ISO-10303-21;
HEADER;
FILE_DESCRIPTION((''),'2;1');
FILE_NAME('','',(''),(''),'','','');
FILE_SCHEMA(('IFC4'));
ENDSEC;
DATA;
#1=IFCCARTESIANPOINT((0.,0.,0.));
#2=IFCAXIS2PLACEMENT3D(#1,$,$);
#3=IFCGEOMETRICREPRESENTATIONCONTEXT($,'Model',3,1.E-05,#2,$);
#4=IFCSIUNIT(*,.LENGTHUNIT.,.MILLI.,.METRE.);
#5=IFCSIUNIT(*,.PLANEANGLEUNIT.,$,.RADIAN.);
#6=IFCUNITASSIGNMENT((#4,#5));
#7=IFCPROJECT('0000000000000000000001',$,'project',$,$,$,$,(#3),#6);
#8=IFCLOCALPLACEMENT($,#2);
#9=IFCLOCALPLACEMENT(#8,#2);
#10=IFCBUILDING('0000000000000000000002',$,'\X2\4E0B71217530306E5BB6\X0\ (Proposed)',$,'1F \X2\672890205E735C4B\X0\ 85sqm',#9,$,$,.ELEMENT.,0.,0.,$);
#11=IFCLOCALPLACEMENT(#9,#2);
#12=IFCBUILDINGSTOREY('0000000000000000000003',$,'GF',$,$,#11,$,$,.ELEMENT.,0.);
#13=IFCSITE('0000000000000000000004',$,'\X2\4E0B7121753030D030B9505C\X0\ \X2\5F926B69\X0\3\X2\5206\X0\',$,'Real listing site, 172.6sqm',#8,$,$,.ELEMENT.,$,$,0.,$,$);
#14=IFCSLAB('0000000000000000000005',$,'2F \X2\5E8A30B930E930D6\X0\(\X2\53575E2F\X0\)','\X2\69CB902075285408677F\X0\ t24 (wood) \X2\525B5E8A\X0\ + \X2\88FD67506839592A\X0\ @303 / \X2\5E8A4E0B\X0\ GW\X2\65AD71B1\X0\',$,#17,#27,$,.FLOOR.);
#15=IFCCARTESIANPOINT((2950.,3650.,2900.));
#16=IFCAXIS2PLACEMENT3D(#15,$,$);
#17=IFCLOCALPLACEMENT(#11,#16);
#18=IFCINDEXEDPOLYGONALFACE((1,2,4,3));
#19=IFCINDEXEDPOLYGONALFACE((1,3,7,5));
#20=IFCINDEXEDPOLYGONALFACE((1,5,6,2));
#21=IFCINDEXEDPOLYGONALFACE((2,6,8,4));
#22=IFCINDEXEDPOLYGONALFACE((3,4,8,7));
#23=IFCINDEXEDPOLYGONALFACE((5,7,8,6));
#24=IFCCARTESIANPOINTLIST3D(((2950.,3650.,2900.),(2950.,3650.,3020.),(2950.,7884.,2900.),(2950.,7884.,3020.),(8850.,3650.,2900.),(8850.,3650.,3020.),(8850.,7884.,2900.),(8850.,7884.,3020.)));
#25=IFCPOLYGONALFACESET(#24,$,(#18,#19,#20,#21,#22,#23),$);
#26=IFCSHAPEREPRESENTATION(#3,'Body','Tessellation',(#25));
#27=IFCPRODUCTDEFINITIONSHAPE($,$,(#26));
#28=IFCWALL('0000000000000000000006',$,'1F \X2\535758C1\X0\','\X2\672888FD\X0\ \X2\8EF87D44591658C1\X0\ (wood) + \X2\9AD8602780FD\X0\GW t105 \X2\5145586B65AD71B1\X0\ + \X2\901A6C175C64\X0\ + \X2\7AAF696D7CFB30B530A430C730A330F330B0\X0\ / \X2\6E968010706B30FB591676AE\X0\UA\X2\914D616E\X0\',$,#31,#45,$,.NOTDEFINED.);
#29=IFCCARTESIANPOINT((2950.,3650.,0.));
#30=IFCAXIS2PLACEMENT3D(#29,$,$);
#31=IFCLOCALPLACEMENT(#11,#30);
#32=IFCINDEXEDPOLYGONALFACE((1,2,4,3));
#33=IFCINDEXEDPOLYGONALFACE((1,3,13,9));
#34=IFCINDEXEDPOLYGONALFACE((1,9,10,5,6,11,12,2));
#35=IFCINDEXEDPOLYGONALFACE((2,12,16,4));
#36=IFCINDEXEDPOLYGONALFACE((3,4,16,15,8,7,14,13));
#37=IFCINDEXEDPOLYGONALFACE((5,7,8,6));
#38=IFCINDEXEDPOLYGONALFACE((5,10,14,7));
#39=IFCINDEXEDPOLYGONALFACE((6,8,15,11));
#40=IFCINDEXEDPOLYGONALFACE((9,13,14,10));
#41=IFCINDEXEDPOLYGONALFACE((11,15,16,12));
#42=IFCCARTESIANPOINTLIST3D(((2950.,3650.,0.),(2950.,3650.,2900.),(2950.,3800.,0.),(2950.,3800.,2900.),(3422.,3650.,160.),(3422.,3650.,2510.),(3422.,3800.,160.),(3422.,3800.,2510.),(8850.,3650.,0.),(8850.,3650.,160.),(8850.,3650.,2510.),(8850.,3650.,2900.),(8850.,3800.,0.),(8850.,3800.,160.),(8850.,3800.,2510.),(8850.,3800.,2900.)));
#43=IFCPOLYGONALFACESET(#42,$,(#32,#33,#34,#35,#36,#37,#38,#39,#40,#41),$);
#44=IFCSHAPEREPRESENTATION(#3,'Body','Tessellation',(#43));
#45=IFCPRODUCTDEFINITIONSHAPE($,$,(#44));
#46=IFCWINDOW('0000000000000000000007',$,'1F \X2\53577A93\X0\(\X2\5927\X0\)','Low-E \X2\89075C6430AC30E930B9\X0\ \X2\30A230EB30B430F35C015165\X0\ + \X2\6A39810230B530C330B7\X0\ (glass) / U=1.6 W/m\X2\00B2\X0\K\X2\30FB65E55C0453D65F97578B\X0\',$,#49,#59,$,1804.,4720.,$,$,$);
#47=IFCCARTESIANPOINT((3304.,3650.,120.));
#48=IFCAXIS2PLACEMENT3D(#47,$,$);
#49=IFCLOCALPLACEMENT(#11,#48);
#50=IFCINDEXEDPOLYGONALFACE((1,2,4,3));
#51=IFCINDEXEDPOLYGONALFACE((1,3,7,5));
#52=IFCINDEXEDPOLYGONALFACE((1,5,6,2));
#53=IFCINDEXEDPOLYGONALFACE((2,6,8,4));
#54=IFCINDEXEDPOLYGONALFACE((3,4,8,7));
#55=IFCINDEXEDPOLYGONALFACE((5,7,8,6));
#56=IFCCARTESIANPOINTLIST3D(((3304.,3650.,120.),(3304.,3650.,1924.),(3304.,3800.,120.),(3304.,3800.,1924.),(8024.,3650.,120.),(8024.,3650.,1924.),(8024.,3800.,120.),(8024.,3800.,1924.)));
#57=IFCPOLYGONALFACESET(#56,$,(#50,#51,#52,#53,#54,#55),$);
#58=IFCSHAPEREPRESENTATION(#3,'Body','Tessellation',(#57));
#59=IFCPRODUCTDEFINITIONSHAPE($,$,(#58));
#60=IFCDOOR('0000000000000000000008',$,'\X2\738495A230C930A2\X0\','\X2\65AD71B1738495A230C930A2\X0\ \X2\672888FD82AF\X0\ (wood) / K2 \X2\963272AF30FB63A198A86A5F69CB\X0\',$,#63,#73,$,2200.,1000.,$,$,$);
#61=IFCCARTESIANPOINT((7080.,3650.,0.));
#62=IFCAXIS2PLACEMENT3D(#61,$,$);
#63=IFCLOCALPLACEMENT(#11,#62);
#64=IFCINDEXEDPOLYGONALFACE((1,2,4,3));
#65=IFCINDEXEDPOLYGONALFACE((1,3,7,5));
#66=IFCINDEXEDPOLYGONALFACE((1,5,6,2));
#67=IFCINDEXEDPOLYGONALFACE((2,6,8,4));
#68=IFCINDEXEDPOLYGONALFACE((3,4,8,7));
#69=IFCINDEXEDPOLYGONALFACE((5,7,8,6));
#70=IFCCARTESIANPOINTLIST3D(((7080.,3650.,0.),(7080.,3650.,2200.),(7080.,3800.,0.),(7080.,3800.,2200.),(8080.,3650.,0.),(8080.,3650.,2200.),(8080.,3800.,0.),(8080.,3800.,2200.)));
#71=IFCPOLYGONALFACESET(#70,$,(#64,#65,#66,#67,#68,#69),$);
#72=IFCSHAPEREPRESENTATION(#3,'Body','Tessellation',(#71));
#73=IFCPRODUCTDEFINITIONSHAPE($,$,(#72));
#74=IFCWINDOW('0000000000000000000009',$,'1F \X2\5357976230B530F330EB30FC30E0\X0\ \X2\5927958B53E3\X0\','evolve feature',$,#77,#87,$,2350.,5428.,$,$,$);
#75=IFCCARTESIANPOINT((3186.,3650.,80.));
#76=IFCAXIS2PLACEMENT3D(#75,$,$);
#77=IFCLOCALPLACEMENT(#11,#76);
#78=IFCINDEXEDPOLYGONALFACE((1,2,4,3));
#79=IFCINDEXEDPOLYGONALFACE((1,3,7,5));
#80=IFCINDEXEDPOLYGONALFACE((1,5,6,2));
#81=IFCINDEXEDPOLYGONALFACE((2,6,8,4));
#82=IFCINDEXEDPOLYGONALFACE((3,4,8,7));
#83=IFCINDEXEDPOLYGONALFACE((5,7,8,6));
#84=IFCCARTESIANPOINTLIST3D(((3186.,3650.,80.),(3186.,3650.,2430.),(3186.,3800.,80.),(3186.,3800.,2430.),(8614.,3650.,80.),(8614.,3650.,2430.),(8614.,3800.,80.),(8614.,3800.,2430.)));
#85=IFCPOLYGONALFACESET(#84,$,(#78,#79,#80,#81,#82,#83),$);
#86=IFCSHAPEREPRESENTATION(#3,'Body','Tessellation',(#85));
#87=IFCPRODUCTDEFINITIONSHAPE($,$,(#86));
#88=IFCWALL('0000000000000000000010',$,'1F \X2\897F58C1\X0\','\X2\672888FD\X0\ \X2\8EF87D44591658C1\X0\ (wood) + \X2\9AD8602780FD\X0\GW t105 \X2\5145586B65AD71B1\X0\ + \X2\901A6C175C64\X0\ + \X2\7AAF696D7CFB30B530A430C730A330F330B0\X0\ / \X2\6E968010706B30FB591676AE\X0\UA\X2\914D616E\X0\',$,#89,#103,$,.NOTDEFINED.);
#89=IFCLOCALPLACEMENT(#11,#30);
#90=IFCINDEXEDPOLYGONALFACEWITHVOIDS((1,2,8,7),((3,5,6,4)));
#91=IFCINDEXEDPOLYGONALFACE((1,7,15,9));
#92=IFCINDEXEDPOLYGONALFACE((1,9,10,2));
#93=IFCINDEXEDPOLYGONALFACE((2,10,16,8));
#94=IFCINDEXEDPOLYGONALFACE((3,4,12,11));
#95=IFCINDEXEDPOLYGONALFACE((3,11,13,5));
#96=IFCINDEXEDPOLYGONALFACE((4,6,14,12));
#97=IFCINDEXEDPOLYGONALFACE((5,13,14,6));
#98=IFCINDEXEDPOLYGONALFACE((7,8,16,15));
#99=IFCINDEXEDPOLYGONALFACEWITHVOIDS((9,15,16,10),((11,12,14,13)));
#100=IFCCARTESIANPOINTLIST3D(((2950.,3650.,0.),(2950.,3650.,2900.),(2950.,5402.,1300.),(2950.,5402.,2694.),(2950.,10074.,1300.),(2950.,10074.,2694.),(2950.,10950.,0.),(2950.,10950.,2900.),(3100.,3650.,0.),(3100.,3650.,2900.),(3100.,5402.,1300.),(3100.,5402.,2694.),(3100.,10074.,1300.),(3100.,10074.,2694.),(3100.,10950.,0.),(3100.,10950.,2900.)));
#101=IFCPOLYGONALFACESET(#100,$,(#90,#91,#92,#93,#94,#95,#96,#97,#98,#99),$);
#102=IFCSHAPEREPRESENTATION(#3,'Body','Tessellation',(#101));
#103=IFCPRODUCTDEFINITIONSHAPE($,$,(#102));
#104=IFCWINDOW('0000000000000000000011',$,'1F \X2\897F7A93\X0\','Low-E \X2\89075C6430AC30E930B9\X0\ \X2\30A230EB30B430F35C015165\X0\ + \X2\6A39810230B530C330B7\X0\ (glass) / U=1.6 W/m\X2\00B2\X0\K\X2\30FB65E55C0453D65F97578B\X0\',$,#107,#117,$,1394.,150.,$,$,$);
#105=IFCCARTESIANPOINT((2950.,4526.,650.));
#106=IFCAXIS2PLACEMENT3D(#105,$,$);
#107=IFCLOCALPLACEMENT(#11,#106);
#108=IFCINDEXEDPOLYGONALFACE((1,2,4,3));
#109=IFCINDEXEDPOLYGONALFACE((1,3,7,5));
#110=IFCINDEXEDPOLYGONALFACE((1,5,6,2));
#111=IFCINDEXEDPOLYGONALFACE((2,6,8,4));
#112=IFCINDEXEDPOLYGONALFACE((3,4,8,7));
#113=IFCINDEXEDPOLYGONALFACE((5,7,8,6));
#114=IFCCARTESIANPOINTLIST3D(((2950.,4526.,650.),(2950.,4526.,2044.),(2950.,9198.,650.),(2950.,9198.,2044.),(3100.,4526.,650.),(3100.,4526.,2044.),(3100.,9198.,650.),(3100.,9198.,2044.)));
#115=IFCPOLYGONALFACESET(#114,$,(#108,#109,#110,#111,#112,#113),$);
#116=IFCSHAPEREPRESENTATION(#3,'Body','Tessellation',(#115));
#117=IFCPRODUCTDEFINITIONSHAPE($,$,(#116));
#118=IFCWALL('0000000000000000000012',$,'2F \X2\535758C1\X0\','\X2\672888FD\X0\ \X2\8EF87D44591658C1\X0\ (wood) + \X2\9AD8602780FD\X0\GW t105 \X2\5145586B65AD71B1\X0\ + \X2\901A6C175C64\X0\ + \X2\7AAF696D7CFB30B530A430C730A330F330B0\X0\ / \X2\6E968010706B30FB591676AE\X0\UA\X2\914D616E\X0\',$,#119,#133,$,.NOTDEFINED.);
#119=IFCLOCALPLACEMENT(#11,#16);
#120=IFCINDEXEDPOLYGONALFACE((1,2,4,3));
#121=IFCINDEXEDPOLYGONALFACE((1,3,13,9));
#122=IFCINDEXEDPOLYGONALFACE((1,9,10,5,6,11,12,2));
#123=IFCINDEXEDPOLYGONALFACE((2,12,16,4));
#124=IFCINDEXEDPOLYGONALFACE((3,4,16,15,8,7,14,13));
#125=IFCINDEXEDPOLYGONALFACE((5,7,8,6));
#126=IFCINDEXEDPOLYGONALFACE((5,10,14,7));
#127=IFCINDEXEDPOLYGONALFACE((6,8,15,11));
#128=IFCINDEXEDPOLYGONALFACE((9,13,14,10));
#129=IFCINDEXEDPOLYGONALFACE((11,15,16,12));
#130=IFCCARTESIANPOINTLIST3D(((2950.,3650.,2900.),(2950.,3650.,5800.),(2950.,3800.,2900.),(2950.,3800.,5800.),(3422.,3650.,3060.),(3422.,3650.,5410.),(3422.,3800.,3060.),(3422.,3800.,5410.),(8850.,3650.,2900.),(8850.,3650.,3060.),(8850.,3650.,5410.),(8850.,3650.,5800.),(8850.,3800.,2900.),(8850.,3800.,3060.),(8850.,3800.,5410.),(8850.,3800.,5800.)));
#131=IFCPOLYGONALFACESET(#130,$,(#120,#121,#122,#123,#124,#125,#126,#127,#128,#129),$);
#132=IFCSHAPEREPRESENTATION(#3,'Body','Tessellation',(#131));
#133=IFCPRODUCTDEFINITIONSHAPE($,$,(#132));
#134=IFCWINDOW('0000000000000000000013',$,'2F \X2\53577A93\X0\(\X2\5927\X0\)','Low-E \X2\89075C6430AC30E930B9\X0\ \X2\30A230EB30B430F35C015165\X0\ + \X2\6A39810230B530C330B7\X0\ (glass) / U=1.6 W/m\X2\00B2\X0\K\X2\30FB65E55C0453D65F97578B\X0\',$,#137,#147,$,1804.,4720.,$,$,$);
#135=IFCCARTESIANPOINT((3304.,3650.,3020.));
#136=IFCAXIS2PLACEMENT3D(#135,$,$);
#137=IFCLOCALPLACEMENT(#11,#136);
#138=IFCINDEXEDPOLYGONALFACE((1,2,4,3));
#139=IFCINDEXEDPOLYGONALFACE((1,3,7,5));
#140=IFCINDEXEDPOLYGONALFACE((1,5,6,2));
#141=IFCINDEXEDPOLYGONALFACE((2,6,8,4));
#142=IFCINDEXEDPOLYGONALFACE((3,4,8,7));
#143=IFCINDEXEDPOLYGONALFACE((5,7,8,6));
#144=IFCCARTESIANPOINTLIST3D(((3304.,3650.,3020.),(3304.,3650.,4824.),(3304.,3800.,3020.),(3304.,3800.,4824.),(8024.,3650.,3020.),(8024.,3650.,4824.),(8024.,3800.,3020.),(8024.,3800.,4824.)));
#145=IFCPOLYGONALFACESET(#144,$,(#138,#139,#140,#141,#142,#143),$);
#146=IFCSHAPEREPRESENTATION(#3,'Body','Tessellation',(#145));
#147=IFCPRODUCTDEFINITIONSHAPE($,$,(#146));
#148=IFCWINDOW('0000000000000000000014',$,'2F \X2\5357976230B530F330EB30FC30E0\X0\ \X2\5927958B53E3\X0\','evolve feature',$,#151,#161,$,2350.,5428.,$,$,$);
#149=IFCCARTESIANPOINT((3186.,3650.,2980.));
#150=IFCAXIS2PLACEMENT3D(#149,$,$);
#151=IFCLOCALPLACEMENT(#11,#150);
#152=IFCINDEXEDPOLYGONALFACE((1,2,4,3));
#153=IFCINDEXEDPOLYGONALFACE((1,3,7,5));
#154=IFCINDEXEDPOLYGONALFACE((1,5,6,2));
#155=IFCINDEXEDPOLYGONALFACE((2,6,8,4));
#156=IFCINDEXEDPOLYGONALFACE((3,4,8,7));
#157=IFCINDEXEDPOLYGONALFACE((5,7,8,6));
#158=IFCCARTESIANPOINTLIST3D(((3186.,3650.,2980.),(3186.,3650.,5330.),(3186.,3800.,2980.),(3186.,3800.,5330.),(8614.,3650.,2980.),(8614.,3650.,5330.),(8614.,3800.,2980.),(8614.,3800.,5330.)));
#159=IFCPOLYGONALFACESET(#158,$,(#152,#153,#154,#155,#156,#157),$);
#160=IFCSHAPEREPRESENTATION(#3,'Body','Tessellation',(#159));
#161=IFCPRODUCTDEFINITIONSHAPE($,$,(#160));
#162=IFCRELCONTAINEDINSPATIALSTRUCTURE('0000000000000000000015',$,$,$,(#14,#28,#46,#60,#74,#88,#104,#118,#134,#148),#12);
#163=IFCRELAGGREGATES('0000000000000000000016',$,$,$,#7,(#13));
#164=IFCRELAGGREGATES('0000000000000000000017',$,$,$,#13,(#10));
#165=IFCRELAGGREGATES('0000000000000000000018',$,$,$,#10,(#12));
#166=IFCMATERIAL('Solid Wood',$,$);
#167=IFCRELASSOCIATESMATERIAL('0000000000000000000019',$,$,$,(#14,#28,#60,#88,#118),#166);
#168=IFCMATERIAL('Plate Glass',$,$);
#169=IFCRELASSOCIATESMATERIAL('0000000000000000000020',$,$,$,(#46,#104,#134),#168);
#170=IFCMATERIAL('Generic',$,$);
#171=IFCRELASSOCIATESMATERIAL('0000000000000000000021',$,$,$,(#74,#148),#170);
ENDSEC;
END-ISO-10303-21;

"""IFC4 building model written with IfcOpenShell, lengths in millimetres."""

from ifc_helpers import new_model, si_unit, frame, frame_2d, origin, place, context, project, spatial, rectangle, extrude, material, element, fill, save


model = new_model("IFC4")

# Units and contexts
model_context = context("Model", 3, precision=1e-05, world=origin())
ifc_project = project(units=[si_unit("LENGTHUNIT", "METRE", prefix="MILLI"), si_unit("PLANEANGLEUNIT", "RADIAN")], contexts=[model_context])

# Site, building, storey
site_placement = place(None, origin())
site = spatial("IfcSite", under=ifc_project, at=site_placement, Name="下無田バス停 徒歩3分", ObjectType="Real listing site, 172.6sqm", CompositionType="ELEMENT", RefElevation=0.0)
building_placement = place(site_placement, origin())
building = spatial("IfcBuilding", under=site, at=building_placement, Name="下無田の家 (Proposed)", ObjectType="1F 木造平屋 85sqm", CompositionType="ELEMENT", ElevationOfRefHeight=0.0, ElevationOfTerrain=0.0)
storey_placement = place(building_placement, origin())
storey = spatial("IfcBuildingStorey", under=building, at=storey_placement, Name="GF", CompositionType="ELEMENT", Elevation=0.0)

# Slab
ifc_material_1 = material(Name="Solid Wood")
slab_1_placement = place(storey_placement, frame((2950.0, 3650.0, 2900.0)))
element("IfcSlab", 1, at=slab_1_placement, inside=storey, material=ifc_material_1, Name="2F 床スラブ(南帯)", Description="構造用合板 t24 (wood) 剛床 + 製材根太 @303 / 床下 GW断熱", PredefinedType="FLOOR", context=model_context, shape_type="SweptSolid", body=[
    extrude(rectangle(XDim=5900.0, YDim=4234.0, at=frame_2d((2950.0, 2117.0))), frame((2950.0, 3650.0, 2900.0)), (0.0, 0.0, 1.0), 120.0),
])
ifc_material_2 = material(Name="Generic")

# Wall, openings, windows, door
wall_1_placement = place(storey_placement, frame((2950.0, 3650.0, 0.0)))
wall_1 = element("IfcWall", 2, at=wall_1_placement, inside=storey, material=ifc_material_1, Name="1F 南壁", Description="木製 軸組外壁 (wood) + 高性能GW t105 充填断熱 + 通気層 + 窯業系サイディング / 準耐火・外皮UA配慮", PredefinedType="NOTDEFINED", context=model_context, shape_type="SweptSolid", body=[
    extrude(rectangle(XDim=5900.0, YDim=150.0, at=frame_2d((2950.0, 75.0))), frame((2950.0, 3650.0, 0.0)), (0.0, 0.0, 1.0), 2900.0),
])
opening_1_placement = place(storey_placement, frame((3304.0, 3650.0, 120.0)))
opening_1 = element("IfcOpeningElement", 3, at=opening_1_placement, cuts=wall_1, PredefinedType="NOTDEFINED", context=model_context, shape_type="SweptSolid", body=[
    extrude(rectangle(XDim=4720.0, YDim=150.0, at=frame_2d((2360.0, 75.0))), frame((3304.0, 3650.0, 120.0)), (0.0, 0.0, 1.0), 1804.0),
])
opening_2_placement = place(storey_placement, frame((7080.0, 3650.0, 0.0)))
opening_2 = element("IfcOpeningElement", 4, at=opening_2_placement, cuts=wall_1, PredefinedType="NOTDEFINED", context=model_context, shape_type="SweptSolid", body=[
    extrude(rectangle(XDim=1000.0, YDim=150.0, at=frame_2d((500.0, 75.0))), frame((7080.0, 3650.0, 0.0)), (0.0, 0.0, 1.0), 2200.0),
])
opening_3_placement = place(storey_placement, frame((3186.0, 3650.0, 80.0)))
opening_3 = element("IfcOpeningElement", 5, at=opening_3_placement, cuts=wall_1, PredefinedType="NOTDEFINED", context=model_context, shape_type="SweptSolid", body=[
    extrude(rectangle(XDim=5428.0, YDim=150.0, at=frame_2d((2714.0, 75.0))), frame((3186.0, 3650.0, 80.0)), (0.0, 0.0, 1.0), 2350.0),
])
ifc_material_3 = material(Name="Plate Glass")
window_1_placement = place(storey_placement, frame((3304.0, 3650.0, 120.0)))
window_1 = element("IfcWindow", 6, at=window_1_placement, inside=storey, material=ifc_material_3, Name="1F 南窓(大)", Description="Low-E 複層ガラス アルゴン封入 + 樹脂サッシ (glass) / U=1.6 W/m²K・日射取得型", OverallHeight=1804.0, OverallWidth=4720.0, context=model_context, shape_type="SweptSolid", body=[
    extrude(rectangle(XDim=4720.0, YDim=150.0, at=frame_2d((2360.0, 75.0))), frame((3304.0, 3650.0, 120.0)), (0.0, 0.0, 1.0), 1804.0),
])
fill(opening_1, window_1)
door_placement = place(storey_placement, frame((7080.0, 3650.0, 0.0)))
door = element("IfcDoor", 7, at=door_placement, inside=storey, material=ifc_material_1, Name="玄関ドア", Description="断熱玄関ドア 木製芯 (wood) / K2 防犯・採風機構", OverallHeight=2200.0, OverallWidth=1000.0, context=model_context, shape_type="SweptSolid", body=[
    extrude(rectangle(XDim=1000.0, YDim=150.0, at=frame_2d((500.0, 75.0))), frame((7080.0, 3650.0, 0.0)), (0.0, 0.0, 1.0), 2200.0),
])
fill(opening_2, door)
window_2_placement = place(storey_placement, frame((3186.0, 3650.0, 80.0)))
window_2 = element("IfcWindow", 8, at=window_2_placement, inside=storey, material=ifc_material_2, Name="1F 南面サンルーム 大開口", Description="evolve feature", OverallHeight=2350.0, OverallWidth=5428.0, context=model_context, shape_type="SweptSolid", body=[
    extrude(rectangle(XDim=5428.0, YDim=150.0, at=frame_2d((2714.0, 75.0))), frame((3186.0, 3650.0, 80.0)), (0.0, 0.0, 1.0), 2350.0),
])
fill(opening_3, window_2)

# Wall, opening, window
wall_2_placement = place(storey_placement, frame((2950.0, 3650.0, 0.0)))
wall_2 = element("IfcWall", 9, at=wall_2_placement, inside=storey, material=ifc_material_1, Name="1F 西壁", Description="木製 軸組外壁 (wood) + 高性能GW t105 充填断熱 + 通気層 + 窯業系サイディング / 準耐火・外皮UA配慮", PredefinedType="NOTDEFINED", context=model_context, shape_type="SweptSolid", body=[
    extrude(rectangle(XDim=150.0, YDim=7300.0, at=frame_2d((75.0, 3650.0))), frame((2950.0, 3650.0, 0.0)), (0.0, 0.0, 1.0), 2900.0),
])
opening_4_placement = place(storey_placement, frame((2950.0, 4526.0, 650.0)))
opening_4 = element("IfcOpeningElement", 10, at=opening_4_placement, cuts=wall_2, PredefinedType="NOTDEFINED", context=model_context, shape_type="SweptSolid", body=[
    extrude(rectangle(XDim=150.0, YDim=4672.0, at=frame_2d((75.0, 2336.0))), frame((2950.0, 4526.0, 650.0)), (0.0, 0.0, 1.0), 1394.0),
])
window_3_placement = place(storey_placement, frame((2950.0, 4526.0, 650.0)))
window_3 = element("IfcWindow", 11, at=window_3_placement, inside=storey, material=ifc_material_3, Name="1F 西窓", Description="Low-E 複層ガラス アルゴン封入 + 樹脂サッシ (glass) / U=1.6 W/m²K・日射取得型", OverallHeight=1394.0, OverallWidth=150.0, context=model_context, shape_type="SweptSolid", body=[
    extrude(rectangle(XDim=150.0, YDim=4672.0, at=frame_2d((75.0, 2336.0))), frame((2950.0, 4526.0, 650.0)), (0.0, 0.0, 1.0), 1394.0),
])
fill(opening_4, window_3)

# Wall, openings, windows
wall_3_placement = place(storey_placement, frame((2950.0, 3650.0, 2900.0)))
wall_3 = element("IfcWall", 12, at=wall_3_placement, inside=storey, material=ifc_material_1, Name="2F 南壁", Description="木製 軸組外壁 (wood) + 高性能GW t105 充填断熱 + 通気層 + 窯業系サイディング / 準耐火・外皮UA配慮", PredefinedType="NOTDEFINED", context=model_context, shape_type="SweptSolid", body=[
    extrude(rectangle(XDim=5900.0, YDim=150.0, at=frame_2d((2950.0, 75.0))), frame((2950.0, 3650.0, 2900.0)), (0.0, 0.0, 1.0), 2900.0),
])
opening_5_placement = place(storey_placement, frame((3304.0, 3650.0, 3020.0)))
opening_5 = element("IfcOpeningElement", 13, at=opening_5_placement, cuts=wall_3, PredefinedType="NOTDEFINED", context=model_context, shape_type="SweptSolid", body=[
    extrude(rectangle(XDim=4720.0, YDim=150.0, at=frame_2d((2360.0, 75.0))), frame((3304.0, 3650.0, 3020.0)), (0.0, 0.0, 1.0), 1804.0),
])
opening_6_placement = place(storey_placement, frame((3186.0, 3650.0, 2980.0)))
opening_6 = element("IfcOpeningElement", 14, at=opening_6_placement, cuts=wall_3, PredefinedType="NOTDEFINED", context=model_context, shape_type="SweptSolid", body=[
    extrude(rectangle(XDim=5428.0, YDim=150.0, at=frame_2d((2714.0, 75.0))), frame((3186.0, 3650.0, 2980.0)), (0.0, 0.0, 1.0), 2350.0),
])
window_4_placement = place(storey_placement, frame((3304.0, 3650.0, 3020.0)))
window_4 = element("IfcWindow", 15, at=window_4_placement, inside=storey, material=ifc_material_3, Name="2F 南窓(大)", Description="Low-E 複層ガラス アルゴン封入 + 樹脂サッシ (glass) / U=1.6 W/m²K・日射取得型", OverallHeight=1804.0, OverallWidth=4720.0, context=model_context, shape_type="SweptSolid", body=[
    extrude(rectangle(XDim=4720.0, YDim=150.0, at=frame_2d((2360.0, 75.0))), frame((3304.0, 3650.0, 3020.0)), (0.0, 0.0, 1.0), 1804.0),
])
fill(opening_5, window_4)
window_5_placement = place(storey_placement, frame((3186.0, 3650.0, 2980.0)))
window_5 = element("IfcWindow", 16, at=window_5_placement, inside=storey, material=ifc_material_2, Name="2F 南面サンルーム 大開口", Description="evolve feature", OverallHeight=2350.0, OverallWidth=5428.0, context=model_context, shape_type="SweptSolid", body=[
    extrude(rectangle(XDim=5428.0, YDim=150.0, at=frame_2d((2714.0, 75.0))), frame((3186.0, 3650.0, 2980.0)), (0.0, 0.0, 1.0), 2350.0),
])
fill(opening_6, window_5)

save(model, "model.ifc")
